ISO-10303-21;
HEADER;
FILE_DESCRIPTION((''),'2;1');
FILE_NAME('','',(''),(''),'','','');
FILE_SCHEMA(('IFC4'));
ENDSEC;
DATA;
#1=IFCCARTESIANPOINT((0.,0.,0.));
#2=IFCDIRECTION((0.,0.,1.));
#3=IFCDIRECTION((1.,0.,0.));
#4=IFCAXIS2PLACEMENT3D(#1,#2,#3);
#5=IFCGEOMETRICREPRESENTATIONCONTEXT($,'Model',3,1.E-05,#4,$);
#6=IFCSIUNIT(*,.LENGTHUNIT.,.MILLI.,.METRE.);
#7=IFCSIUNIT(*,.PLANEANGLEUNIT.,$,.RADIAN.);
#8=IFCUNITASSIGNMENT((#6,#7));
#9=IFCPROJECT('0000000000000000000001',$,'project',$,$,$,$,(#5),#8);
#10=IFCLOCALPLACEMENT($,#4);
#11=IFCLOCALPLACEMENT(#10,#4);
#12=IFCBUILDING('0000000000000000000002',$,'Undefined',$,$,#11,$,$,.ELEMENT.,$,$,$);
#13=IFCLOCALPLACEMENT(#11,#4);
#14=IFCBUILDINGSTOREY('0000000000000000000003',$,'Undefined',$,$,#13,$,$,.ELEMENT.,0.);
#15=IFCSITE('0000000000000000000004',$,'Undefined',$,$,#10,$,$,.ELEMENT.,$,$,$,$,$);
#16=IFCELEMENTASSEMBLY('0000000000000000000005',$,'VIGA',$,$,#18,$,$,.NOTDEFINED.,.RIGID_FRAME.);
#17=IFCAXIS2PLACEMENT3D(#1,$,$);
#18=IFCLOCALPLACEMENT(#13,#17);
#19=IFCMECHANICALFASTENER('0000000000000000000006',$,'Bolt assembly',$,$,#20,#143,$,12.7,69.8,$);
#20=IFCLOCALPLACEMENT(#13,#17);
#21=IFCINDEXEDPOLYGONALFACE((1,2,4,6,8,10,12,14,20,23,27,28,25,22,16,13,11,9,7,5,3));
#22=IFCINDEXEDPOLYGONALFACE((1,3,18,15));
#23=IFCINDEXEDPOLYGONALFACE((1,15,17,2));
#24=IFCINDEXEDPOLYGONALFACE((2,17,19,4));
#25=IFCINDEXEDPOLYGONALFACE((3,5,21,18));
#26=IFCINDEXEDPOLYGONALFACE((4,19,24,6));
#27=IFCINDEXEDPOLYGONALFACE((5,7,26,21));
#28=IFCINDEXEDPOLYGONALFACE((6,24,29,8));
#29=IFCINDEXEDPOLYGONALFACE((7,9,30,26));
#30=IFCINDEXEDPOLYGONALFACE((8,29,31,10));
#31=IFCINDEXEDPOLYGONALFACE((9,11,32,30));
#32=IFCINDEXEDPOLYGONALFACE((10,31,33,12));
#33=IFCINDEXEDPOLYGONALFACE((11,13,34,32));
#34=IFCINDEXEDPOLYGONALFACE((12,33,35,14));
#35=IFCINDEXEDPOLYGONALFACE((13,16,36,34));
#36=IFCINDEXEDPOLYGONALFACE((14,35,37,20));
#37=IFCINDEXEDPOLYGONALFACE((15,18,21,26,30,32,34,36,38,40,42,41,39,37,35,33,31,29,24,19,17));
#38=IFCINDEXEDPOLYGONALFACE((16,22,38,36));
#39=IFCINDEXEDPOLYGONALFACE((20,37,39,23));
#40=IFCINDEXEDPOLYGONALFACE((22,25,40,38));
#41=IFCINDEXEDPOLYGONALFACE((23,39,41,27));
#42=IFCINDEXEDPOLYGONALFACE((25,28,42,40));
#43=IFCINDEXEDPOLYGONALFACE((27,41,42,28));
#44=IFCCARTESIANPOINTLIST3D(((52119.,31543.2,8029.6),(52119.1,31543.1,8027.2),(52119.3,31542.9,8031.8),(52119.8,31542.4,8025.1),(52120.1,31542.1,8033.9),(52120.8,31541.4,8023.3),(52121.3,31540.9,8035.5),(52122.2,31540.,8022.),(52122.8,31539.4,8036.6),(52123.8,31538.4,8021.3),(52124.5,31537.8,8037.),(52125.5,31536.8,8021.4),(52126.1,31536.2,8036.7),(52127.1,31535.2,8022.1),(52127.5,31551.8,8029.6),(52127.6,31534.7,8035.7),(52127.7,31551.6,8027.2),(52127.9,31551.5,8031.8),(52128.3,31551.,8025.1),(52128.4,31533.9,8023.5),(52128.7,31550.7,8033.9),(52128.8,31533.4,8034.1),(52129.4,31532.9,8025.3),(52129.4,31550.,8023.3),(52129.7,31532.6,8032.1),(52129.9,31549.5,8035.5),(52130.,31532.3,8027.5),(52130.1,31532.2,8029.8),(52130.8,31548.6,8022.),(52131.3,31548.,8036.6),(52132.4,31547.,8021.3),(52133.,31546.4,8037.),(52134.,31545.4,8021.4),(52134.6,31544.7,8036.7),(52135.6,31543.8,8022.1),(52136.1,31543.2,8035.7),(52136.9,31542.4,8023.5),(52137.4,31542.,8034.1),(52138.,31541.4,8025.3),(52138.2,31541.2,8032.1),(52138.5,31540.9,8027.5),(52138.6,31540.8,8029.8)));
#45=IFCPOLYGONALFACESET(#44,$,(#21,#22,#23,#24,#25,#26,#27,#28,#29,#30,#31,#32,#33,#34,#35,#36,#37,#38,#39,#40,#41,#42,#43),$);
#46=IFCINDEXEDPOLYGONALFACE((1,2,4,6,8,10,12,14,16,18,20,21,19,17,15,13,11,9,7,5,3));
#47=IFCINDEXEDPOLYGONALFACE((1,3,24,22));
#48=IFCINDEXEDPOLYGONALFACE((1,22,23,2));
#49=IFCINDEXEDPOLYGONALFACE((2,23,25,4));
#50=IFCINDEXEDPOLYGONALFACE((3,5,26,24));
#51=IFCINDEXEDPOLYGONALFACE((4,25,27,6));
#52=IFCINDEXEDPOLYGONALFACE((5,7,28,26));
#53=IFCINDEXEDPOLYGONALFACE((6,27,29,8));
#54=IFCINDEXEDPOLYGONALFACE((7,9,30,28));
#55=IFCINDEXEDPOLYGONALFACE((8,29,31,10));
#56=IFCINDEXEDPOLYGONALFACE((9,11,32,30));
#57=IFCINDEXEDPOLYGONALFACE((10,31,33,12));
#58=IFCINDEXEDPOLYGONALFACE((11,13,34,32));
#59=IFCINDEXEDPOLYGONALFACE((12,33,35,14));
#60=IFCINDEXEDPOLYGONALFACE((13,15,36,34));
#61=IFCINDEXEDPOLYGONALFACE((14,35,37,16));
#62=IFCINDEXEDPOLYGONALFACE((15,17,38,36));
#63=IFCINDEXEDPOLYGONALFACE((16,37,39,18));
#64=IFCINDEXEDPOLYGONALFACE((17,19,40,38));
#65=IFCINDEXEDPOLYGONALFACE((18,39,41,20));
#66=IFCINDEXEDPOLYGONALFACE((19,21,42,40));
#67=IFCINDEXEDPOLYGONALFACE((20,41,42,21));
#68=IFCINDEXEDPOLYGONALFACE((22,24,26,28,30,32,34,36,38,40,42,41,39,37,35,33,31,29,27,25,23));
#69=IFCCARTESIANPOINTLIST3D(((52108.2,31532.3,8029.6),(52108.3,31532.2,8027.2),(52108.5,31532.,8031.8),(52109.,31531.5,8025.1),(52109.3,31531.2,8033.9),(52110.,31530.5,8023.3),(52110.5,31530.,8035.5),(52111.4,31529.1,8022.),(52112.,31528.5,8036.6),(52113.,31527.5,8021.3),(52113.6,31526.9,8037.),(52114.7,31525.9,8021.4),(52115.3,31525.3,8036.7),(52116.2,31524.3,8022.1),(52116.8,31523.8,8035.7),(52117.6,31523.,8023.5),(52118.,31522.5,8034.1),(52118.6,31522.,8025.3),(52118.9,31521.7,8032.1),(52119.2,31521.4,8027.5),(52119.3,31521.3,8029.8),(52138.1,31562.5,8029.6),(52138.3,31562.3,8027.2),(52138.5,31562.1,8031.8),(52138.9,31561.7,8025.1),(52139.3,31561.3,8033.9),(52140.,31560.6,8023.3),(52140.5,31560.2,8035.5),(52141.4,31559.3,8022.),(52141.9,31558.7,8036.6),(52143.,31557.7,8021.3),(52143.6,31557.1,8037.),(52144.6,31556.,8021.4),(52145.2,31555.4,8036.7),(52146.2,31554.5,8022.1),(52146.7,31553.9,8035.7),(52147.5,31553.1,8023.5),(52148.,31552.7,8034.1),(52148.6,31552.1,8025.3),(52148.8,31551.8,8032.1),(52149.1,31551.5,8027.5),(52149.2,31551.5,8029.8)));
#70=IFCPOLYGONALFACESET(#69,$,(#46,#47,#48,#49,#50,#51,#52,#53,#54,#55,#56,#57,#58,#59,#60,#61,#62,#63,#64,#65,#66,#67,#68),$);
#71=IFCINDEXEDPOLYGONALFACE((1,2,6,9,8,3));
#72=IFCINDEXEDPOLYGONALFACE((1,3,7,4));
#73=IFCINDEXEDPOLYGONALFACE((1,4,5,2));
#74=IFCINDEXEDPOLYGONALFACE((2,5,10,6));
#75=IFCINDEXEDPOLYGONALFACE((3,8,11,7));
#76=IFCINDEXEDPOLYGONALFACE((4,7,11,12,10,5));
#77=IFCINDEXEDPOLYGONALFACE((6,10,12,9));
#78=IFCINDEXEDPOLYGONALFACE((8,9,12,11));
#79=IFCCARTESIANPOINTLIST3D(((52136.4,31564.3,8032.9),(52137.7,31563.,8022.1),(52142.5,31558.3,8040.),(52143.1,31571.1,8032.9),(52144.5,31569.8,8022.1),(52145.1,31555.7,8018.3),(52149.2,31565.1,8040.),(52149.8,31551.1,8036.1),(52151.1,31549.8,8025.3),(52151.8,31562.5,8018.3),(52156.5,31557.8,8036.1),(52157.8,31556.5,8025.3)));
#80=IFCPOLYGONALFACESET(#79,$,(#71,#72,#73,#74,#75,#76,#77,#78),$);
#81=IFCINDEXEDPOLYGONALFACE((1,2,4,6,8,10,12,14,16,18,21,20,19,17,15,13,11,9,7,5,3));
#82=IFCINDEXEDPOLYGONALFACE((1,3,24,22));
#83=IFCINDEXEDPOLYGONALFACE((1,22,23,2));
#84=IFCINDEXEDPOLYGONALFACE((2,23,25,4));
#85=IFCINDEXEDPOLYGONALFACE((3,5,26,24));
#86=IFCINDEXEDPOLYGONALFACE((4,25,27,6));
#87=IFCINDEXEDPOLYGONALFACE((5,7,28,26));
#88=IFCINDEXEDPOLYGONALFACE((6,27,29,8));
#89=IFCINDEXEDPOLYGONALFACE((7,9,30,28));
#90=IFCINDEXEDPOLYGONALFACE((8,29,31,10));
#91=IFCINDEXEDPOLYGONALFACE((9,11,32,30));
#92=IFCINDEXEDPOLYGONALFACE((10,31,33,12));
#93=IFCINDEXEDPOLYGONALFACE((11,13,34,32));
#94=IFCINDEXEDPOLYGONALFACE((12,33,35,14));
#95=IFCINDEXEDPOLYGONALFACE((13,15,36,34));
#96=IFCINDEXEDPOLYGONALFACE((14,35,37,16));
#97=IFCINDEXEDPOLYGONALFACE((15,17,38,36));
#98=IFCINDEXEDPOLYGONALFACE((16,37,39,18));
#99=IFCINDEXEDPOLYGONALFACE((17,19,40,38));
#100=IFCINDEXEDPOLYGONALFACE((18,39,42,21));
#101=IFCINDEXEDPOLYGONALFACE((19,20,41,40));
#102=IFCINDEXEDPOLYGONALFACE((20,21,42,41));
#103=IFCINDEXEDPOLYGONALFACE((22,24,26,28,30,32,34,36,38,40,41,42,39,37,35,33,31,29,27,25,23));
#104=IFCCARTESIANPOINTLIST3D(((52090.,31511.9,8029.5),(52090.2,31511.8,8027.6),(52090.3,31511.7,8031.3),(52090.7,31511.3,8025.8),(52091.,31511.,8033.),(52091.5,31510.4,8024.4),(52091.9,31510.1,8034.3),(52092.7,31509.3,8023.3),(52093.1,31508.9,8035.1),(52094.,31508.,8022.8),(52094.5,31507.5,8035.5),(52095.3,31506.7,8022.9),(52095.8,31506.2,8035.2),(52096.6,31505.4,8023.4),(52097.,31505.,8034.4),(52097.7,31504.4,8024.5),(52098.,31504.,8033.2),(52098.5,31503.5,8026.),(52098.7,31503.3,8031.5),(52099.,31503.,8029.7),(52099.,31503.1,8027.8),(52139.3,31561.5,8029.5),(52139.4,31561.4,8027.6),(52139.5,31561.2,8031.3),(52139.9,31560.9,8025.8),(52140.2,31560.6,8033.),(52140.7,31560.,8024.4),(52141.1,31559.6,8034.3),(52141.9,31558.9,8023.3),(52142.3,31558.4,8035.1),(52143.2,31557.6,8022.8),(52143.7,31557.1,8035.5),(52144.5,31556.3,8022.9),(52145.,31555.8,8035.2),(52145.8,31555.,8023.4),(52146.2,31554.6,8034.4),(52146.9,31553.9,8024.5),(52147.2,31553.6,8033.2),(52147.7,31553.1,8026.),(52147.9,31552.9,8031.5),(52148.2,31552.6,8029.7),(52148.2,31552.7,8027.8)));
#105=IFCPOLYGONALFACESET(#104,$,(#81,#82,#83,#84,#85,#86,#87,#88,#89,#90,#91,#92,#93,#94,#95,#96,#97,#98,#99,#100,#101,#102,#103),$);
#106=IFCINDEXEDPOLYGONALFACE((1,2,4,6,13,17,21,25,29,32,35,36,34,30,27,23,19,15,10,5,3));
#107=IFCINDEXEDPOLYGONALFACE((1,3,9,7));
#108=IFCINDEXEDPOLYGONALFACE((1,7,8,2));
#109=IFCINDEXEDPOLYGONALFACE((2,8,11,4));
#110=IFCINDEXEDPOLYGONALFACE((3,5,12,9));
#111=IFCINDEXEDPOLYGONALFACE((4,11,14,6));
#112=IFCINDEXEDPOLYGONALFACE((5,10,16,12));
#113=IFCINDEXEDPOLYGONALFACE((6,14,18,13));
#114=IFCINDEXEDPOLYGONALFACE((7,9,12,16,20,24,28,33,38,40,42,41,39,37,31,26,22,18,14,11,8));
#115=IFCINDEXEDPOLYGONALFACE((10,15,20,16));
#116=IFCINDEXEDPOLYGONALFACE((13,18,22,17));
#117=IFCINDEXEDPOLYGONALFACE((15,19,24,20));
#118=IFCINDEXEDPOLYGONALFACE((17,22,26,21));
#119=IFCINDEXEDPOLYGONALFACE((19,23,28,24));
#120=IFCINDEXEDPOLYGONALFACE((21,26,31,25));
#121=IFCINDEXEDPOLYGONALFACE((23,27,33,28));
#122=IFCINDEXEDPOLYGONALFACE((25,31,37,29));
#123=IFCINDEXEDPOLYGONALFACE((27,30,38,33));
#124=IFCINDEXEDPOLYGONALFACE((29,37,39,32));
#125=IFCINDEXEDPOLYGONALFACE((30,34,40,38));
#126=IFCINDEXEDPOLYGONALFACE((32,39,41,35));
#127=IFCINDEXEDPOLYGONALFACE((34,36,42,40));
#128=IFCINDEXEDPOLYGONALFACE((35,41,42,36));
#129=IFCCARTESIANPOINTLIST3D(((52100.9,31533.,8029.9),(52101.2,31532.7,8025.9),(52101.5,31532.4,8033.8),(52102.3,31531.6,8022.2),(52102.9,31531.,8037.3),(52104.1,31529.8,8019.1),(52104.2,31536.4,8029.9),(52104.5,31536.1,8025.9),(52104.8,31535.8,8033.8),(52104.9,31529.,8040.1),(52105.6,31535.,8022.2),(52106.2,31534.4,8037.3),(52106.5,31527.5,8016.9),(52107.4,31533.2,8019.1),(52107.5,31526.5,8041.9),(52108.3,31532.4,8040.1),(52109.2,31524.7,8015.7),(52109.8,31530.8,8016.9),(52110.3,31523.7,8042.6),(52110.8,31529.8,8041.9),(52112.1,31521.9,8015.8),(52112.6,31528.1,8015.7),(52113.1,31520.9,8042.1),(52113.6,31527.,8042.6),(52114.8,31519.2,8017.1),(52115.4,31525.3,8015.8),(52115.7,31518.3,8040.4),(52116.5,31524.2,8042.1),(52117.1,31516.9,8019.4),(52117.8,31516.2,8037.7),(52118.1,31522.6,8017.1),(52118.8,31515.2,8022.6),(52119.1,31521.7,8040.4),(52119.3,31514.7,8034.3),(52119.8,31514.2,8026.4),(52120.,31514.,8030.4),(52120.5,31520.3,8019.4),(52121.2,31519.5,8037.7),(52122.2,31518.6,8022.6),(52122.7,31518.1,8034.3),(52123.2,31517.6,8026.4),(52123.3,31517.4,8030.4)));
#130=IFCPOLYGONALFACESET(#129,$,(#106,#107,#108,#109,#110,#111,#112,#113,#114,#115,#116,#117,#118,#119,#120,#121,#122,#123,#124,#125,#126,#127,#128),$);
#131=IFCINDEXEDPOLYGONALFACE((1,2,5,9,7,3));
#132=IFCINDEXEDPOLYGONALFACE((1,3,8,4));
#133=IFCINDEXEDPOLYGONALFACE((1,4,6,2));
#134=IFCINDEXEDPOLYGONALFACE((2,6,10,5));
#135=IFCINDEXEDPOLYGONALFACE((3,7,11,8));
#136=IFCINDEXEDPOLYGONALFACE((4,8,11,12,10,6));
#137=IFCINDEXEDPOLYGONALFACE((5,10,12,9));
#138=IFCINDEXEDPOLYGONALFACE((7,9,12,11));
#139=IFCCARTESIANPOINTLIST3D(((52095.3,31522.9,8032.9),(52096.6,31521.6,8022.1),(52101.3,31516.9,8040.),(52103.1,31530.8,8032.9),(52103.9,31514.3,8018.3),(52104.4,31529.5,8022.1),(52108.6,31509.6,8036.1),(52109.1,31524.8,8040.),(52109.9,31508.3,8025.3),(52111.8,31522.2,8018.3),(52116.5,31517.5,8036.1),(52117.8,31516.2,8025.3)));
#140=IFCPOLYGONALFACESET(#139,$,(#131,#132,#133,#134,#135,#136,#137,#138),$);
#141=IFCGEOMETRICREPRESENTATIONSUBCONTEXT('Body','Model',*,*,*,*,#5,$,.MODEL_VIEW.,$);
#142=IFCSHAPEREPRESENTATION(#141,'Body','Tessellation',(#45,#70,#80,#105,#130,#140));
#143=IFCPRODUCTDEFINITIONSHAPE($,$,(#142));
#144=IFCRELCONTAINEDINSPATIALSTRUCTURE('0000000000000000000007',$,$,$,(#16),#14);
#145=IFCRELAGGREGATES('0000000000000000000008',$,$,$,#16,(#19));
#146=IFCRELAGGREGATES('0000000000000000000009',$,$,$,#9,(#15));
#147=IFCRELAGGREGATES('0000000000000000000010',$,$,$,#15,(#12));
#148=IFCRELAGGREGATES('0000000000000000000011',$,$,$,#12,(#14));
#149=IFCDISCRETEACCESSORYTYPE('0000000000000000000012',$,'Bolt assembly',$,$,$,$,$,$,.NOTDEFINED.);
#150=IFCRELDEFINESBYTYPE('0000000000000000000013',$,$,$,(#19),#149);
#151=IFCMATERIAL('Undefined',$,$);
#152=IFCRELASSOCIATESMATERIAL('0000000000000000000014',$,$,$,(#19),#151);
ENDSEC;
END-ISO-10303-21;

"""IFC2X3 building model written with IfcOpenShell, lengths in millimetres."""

from ifc_helpers import new_model, si_unit, frame, origin_with_axes, origin_2d_with_axis, place, context, subcontext, project, spatial, polyline, circle, outline, extrude, source, transform, mapped, material, type_object, element, aggregate, save


model = new_model("IFC2X3")

# Units and contexts
model_context = context("Model", 3, precision=1e-05, world=origin_with_axes())
body_context = subcontext(model_context, "Body", "Model", "MODEL_VIEW")
ifc_project = project(units=[si_unit("LENGTHUNIT", "METRE", prefix="MILLI"), si_unit("PLANEANGLEUNIT", "RADIAN")], contexts=[model_context])

# Site, building, storey
site_placement = place(None, origin_with_axes())
site = spatial("IfcSite", under=ifc_project, at=site_placement, Name="Undefined", CompositionType="ELEMENT")
building_placement = place(site_placement, origin_with_axes())
building = spatial("IfcBuilding", under=site, at=building_placement, Name="Undefined", CompositionType="ELEMENT")
storey_placement = place(building_placement, origin_with_axes())
storey = spatial("IfcBuildingStorey", under=building, at=storey_placement, Name="Undefined", CompositionType="ELEMENT", Elevation=0.0)

# Element assembly
assembly_1_placement = place(storey_placement, origin_with_axes())
assembly_1 = element("IfcElementAssembly", 1, at=assembly_1_placement, inside=storey, Name="VIGA", AssemblyPlace="NOTDEFINED", PredefinedType="RIGID_FRAME")

# Shared definitions
ifc_material_1 = material(Name="Undefined")
discrete_accessory_type_1 = type_object("IfcDiscreteAccessoryType", Name="Bolt assembly")

# Mechanical fastener
shared_shape_1 = source(origin_with_axes(), body_context, "Body", "SweptSolid", [
    extrude(circle(Radius=7.8, at=origin_2d_with_axis()), frame((0.0, -6.1, 0.0), z_axis=(0.0, 1.0, 0.0), x_axis=(1.0, 0.0, 0.0)), (0.0, 0.0, 1.0), 12.1),
    extrude(circle(Radius=7.8, at=origin_2d_with_axis()), frame((0.0, -21.2, 0.0), z_axis=(0.0, 1.0, 0.0), x_axis=(1.0, 0.0, 0.0)), (0.0, 0.0, 1.0), 42.5),
    extrude(outline(polyline([(11.0, 0.0), (5.5, 9.5), (-5.5, 9.5), (-11.0, 0.0), (-5.5, -9.5), (5.5, -9.5), (11.0, 0.0)])), frame((0.0, -30.8, 0.0), z_axis=(0.0, 1.0, 0.0), x_axis=(1.0, 0.0, 0.0)), (0.0, 0.0, 1.0), 9.5),
    extrude(circle(Radius=6.3, at=origin_2d_with_axis()), frame((0.0, -21.3, 0.0), z_axis=(0.0, 1.0, 0.0), x_axis=(1.0, 0.0, 0.0)), (0.0, 0.0, 1.0), 69.8),
    extrude(circle(Radius=13.5, at=origin_2d_with_axis()), frame((0.0, 21.2, 0.0), z_axis=(0.0, 1.0, 0.0), x_axis=(1.0, 0.0, 0.0)), (0.0, 0.0, 1.0), 4.8),
    extrude(outline(polyline([(11.0, 0.0), (5.5, 9.5), (-5.5, 9.5), (-11.0, 0.0), (-5.5, -9.5), (5.5, -9.5), (11.0, 0.0)])), frame((0.0, 26.0, 0.0), z_axis=(0.0, 1.0, 0.0), x_axis=(1.0, 0.0, 0.0)), (0.0, 0.0, 1.0), 11.1),
])
mechanical_fastener_1_placement = place(assembly_1_placement, frame((52128.8, 31542.0, 8029.1), z_axis=(0.247001, -0.245233, 0.937471), x_axis=(-0.665269, 0.660506, 0.348064)))
mechanical_fastener_1 = element("IfcMechanicalFastener", 2, at=mechanical_fastener_1_placement, type_object=discrete_accessory_type_1, material=ifc_material_1, Name="Bolt assembly", NominalDiameter=12.7, NominalLength=69.8, context=body_context, shape_type="MappedRepresentation", body=[
    mapped(shared_shape_1, transform((0.0, 0.0, 0.0))),
])
aggregate(assembly_1, [mechanical_fastener_1])

save(model, "model.ifc")
